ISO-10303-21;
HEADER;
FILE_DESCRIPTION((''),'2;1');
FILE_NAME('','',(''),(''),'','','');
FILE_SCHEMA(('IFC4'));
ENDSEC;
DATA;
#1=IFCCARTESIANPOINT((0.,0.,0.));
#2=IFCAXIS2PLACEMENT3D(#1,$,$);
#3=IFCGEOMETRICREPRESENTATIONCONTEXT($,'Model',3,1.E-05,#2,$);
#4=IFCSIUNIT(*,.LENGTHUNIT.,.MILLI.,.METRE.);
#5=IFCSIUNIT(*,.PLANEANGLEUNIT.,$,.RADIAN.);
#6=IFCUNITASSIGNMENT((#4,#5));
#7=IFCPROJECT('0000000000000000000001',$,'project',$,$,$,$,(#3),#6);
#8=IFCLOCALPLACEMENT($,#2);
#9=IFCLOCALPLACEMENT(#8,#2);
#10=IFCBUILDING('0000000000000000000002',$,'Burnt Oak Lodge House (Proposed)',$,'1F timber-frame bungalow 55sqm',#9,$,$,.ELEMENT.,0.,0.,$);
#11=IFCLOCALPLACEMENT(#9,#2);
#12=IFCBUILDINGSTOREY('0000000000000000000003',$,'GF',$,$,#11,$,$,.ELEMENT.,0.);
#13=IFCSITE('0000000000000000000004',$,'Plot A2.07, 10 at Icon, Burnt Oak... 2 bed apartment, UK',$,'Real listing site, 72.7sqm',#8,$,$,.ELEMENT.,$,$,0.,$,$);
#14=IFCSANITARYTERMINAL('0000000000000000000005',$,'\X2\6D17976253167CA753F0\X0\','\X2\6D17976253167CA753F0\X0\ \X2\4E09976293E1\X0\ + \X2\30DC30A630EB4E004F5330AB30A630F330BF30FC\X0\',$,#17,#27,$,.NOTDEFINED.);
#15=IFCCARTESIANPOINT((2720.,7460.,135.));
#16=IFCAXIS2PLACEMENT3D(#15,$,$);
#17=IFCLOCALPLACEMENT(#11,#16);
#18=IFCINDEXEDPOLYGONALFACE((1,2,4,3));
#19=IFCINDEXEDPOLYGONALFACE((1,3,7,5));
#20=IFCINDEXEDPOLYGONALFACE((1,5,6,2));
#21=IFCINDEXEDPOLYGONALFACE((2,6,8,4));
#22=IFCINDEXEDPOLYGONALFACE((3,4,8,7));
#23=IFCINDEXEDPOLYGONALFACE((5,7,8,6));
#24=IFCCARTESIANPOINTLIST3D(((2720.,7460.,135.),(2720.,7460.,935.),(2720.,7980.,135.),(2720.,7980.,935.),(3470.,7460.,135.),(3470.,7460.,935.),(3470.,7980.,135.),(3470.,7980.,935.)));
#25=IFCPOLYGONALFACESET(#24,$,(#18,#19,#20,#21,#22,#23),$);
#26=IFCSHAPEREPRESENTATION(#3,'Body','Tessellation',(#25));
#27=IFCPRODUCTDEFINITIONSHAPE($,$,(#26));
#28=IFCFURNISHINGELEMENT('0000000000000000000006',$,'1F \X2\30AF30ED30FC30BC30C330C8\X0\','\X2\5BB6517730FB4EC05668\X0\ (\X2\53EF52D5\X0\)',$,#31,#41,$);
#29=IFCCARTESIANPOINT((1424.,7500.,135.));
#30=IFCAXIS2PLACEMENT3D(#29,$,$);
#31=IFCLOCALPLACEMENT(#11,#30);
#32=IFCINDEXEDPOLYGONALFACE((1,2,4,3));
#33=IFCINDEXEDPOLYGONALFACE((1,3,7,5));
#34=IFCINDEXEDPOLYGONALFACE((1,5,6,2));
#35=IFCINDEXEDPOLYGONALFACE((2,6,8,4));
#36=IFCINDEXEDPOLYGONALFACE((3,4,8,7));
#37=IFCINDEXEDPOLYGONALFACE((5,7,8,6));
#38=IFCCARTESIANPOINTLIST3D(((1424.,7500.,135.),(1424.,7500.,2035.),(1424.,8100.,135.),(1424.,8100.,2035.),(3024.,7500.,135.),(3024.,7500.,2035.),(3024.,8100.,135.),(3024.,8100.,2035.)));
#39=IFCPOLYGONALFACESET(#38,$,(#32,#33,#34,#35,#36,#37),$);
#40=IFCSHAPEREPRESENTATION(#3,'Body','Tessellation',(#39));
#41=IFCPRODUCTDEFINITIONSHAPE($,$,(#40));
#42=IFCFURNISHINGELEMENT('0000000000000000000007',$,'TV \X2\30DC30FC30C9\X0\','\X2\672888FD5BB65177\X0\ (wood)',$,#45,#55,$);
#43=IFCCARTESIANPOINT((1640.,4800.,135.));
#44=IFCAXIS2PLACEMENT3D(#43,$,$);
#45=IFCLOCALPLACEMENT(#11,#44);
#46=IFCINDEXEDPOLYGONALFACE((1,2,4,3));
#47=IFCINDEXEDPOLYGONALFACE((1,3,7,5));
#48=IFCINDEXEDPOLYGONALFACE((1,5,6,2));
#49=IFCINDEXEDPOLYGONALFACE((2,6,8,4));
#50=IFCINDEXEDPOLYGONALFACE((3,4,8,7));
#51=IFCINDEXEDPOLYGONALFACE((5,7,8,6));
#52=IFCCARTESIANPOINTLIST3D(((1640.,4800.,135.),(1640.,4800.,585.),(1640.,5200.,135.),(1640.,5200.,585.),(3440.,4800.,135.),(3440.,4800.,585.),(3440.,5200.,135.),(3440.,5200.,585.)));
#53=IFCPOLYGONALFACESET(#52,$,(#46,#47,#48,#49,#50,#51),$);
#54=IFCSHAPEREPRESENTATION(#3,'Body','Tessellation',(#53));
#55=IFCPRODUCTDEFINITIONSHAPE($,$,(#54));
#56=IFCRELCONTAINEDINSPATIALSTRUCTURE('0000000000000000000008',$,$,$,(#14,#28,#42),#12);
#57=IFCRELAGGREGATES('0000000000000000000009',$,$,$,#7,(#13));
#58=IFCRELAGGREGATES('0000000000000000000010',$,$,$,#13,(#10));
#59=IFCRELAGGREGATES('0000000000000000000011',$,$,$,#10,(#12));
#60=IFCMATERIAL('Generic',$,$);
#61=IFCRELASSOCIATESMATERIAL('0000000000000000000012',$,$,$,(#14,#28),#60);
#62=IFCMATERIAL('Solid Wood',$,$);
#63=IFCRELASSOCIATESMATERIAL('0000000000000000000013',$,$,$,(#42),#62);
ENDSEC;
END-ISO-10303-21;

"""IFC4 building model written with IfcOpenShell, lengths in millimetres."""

from ifc_helpers import new_model, si_unit, frame, frame_2d, origin, place, context, project, spatial, rectangle, extrude, material, element, save


model = new_model("IFC4")

# Units and contexts
model_context = context("Model", 3, precision=1e-05, world=origin())
ifc_project = project(units=[si_unit("LENGTHUNIT", "METRE", prefix="MILLI"), si_unit("PLANEANGLEUNIT", "RADIAN")], contexts=[model_context])

# Site, building, storey
site_placement = place(None, origin())
site = spatial("IfcSite", under=ifc_project, at=site_placement, Name="Plot A2.07, 10 at Icon, Burnt Oak... 2 bed apartment, UK", ObjectType="Real listing site, 72.7sqm", CompositionType="ELEMENT", RefElevation=0.0)
building_placement = place(site_placement, origin())
building = spatial("IfcBuilding", under=site, at=building_placement, Name="Burnt Oak Lodge House (Proposed)", ObjectType="1F timber-frame bungalow 55sqm", CompositionType="ELEMENT", ElevationOfRefHeight=0.0, ElevationOfTerrain=0.0)
storey_placement = place(building_placement, origin())
storey = spatial("IfcBuildingStorey", under=building, at=storey_placement, Name="GF", CompositionType="ELEMENT", Elevation=0.0)

# Shared definitions
ifc_material_1 = material(Name="Solid Wood")

# Shared definitions
ifc_material_2 = material(Name="Generic")

# Sanitary terminal
sanitary_terminal_1_placement = place(storey_placement, frame((2720.0, 7460.0, 135.0)))
element("IfcSanitaryTerminal", 1, at=sanitary_terminal_1_placement, inside=storey, material=ifc_material_2, Name="洗面化粧台", Description="洗面化粧台 三面鏡 + ボウル一体カウンター", PredefinedType="NOTDEFINED", context=model_context, shape_type="SweptSolid", body=[
    extrude(rectangle(XDim=750.0, YDim=520.0, at=frame_2d((375.0, 260.0))), frame((2720.0, 7460.0, 135.0)), (0.0, 0.0, 1.0), 800.0),
])

# Furnishing elements
furnishing_1_placement = place(storey_placement, frame((1424.0, 7500.0, 135.0)))
element("IfcFurnishingElement", 2, at=furnishing_1_placement, inside=storey, material=ifc_material_2, Name="1F クローゼット", Description="家具・什器 (可動)", context=model_context, shape_type="SweptSolid", body=[
    extrude(rectangle(XDim=1600.0, YDim=600.0, at=frame_2d((800.0, 300.0))), frame((1424.0, 7500.0, 135.0)), (0.0, 0.0, 1.0), 1900.0),
])
furnishing_2_placement = place(storey_placement, frame((1640.0, 4800.0, 135.0)))
element("IfcFurnishingElement", 3, at=furnishing_2_placement, inside=storey, material=ifc_material_1, Name="TV ボード", Description="木製家具 (wood)", context=model_context, shape_type="SweptSolid", body=[
    extrude(rectangle(XDim=1800.0, YDim=400.0, at=frame_2d((900.0, 200.0))), frame((1640.0, 4800.0, 135.0)), (0.0, 0.0, 1.0), 450.0),
])

save(model, "model.ifc")
